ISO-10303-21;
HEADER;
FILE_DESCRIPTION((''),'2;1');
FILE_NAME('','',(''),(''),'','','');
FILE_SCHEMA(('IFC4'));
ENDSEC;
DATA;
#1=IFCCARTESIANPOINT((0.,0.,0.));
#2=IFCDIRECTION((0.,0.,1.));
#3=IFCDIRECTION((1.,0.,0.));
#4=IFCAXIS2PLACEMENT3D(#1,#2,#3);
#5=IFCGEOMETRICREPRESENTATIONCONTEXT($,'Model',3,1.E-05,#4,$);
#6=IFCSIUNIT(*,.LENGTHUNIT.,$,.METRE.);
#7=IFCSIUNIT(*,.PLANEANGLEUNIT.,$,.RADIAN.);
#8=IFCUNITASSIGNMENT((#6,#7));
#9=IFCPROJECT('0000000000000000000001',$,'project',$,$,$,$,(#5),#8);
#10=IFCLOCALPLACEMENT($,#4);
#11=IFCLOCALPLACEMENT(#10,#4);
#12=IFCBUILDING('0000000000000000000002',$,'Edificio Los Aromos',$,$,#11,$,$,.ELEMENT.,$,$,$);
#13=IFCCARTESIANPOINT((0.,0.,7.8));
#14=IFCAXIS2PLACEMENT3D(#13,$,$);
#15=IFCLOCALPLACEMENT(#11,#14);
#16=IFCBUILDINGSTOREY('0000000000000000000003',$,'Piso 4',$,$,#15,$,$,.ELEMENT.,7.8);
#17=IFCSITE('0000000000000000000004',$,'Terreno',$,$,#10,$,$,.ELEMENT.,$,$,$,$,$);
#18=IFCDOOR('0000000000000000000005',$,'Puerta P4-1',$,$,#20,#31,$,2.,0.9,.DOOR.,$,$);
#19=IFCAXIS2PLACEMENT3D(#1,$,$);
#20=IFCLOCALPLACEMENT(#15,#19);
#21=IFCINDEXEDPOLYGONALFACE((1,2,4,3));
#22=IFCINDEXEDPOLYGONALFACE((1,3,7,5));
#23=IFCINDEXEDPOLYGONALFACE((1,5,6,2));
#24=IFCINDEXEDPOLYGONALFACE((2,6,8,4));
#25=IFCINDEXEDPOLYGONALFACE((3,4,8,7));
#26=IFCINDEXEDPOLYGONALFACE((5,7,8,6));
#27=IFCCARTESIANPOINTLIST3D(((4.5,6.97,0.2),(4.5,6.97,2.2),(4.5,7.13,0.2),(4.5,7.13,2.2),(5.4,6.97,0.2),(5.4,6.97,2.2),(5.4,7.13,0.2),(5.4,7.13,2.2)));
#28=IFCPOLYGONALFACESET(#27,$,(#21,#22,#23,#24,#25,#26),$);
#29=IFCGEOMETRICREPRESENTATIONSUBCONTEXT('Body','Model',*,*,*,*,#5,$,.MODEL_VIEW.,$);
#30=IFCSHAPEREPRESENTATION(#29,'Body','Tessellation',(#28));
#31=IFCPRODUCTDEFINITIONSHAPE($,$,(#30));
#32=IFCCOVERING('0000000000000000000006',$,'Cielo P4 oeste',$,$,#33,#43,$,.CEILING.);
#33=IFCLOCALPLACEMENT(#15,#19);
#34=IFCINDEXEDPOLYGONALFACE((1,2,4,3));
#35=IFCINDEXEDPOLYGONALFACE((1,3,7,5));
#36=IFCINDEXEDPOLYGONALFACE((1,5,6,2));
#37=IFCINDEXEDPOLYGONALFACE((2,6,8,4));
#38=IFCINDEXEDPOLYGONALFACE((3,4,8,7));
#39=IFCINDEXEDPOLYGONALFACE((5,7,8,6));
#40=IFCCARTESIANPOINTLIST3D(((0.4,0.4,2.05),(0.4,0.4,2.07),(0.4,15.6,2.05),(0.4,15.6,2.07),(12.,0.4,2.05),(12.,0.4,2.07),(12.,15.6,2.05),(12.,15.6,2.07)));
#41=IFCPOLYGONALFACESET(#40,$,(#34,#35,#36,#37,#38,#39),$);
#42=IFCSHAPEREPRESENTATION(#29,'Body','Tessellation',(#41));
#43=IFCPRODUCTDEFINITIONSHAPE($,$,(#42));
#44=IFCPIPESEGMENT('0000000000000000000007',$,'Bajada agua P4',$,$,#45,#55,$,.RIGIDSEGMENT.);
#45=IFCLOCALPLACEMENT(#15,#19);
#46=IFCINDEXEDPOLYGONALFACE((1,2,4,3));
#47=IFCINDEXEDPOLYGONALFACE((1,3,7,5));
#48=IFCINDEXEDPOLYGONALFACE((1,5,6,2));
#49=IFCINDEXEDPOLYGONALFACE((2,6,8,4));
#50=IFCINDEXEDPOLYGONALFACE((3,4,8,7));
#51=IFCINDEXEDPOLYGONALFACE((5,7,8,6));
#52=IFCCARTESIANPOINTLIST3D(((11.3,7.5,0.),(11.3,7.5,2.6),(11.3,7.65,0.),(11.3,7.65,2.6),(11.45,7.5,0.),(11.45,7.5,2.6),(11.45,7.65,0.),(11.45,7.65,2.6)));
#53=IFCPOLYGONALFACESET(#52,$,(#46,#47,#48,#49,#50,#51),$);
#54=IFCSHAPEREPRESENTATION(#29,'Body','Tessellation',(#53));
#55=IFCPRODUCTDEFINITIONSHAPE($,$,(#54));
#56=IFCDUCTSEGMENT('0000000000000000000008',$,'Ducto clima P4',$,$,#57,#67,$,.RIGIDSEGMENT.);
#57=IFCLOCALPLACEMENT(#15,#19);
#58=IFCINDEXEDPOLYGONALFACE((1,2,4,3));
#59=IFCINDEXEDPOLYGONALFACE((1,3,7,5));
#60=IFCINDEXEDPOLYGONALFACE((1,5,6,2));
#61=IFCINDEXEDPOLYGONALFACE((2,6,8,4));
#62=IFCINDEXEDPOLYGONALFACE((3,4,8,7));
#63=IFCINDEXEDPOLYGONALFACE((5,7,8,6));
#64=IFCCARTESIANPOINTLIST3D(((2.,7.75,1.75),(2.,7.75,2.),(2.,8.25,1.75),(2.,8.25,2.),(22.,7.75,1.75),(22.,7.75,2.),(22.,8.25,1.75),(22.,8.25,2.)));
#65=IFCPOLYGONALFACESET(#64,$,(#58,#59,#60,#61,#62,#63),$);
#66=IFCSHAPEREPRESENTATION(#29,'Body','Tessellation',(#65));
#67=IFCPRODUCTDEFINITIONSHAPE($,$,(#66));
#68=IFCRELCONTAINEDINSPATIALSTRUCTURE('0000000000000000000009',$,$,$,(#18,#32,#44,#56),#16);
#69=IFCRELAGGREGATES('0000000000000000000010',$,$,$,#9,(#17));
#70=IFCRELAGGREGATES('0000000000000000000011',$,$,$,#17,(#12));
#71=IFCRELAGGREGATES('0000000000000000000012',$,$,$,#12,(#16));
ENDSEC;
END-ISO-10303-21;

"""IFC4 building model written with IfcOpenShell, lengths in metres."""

from ifc_helpers import new_model, si_unit, frame, frame_2d, origin_with_axes, place, context, subcontext, project, spatial, rectangle, extrude, element, save


model = new_model("IFC4")

# Units and contexts
model_context = context("Model", 3, precision=1e-05, world=origin_with_axes())
body_context = subcontext(model_context, "Body", "Model", "MODEL_VIEW")
ifc_project = project(units=[si_unit("LENGTHUNIT", "METRE"), si_unit("PLANEANGLEUNIT", "RADIAN")], contexts=[model_context])

# Site, building, storey
site_placement = place(None, origin_with_axes())
site = spatial("IfcSite", under=ifc_project, at=site_placement, Name="Terreno", CompositionType="ELEMENT")
building_placement = place(site_placement, origin_with_axes())
building = spatial("IfcBuilding", under=site, at=building_placement, Name="Edificio Los Aromos", CompositionType="ELEMENT")
storey_placement = place(building_placement, frame((0.0, 0.0, 7.8)))
storey = spatial("IfcBuildingStorey", under=building, at=storey_placement, Name="Piso 4", CompositionType="ELEMENT", Elevation=7.8)

# Door
door_placement = place(storey_placement, frame((4.5, 6.97, 0.2)))
element("IfcDoor", 1, at=door_placement, inside=storey, Name="Puerta P4-1", OverallHeight=2.0, OverallWidth=0.9, PredefinedType="DOOR", context=body_context, shape_type="SweptSolid", body=[
    extrude(rectangle(XDim=0.9, YDim=0.16, at=frame_2d((0.45, 0.08))), origin_with_axes(), (0.0, 0.0, 1.0), 2.0),
])

# Covering
covering_placement = place(storey_placement, frame((0.4, 0.4, 2.05)))
element("IfcCovering", 2, at=covering_placement, inside=storey, Name="Cielo P4 oeste", PredefinedType="CEILING", context=body_context, shape_type="SweptSolid", body=[
    extrude(rectangle(XDim=11.6, YDim=15.2, at=frame_2d((5.8, 7.6))), origin_with_axes(), (0.0, 0.0, 1.0), 0.02),
])

# Pipe segment
pipe_segment_placement = place(storey_placement, frame((11.3, 7.5, 0.0)))
element("IfcPipeSegment", 3, at=pipe_segment_placement, inside=storey, Name="Bajada agua P4", PredefinedType="RIGIDSEGMENT", context=body_context, shape_type="SweptSolid", body=[
    extrude(rectangle(XDim=0.15, YDim=0.15, at=frame_2d((0.075, 0.075))), origin_with_axes(), (0.0, 0.0, 1.0), 2.6),
])

# Duct segment
duct_segment_placement = place(storey_placement, frame((2.0, 7.75, 1.75)))
element("IfcDuctSegment", 4, at=duct_segment_placement, inside=storey, Name="Ducto clima P4", PredefinedType="RIGIDSEGMENT", context=body_context, shape_type="SweptSolid", body=[
    extrude(rectangle(XDim=20.0, YDim=0.5, at=frame_2d((10.0, 0.25))), origin_with_axes(), (0.0, 0.0, 1.0), 0.25),
])

save(model, "model.ifc")
